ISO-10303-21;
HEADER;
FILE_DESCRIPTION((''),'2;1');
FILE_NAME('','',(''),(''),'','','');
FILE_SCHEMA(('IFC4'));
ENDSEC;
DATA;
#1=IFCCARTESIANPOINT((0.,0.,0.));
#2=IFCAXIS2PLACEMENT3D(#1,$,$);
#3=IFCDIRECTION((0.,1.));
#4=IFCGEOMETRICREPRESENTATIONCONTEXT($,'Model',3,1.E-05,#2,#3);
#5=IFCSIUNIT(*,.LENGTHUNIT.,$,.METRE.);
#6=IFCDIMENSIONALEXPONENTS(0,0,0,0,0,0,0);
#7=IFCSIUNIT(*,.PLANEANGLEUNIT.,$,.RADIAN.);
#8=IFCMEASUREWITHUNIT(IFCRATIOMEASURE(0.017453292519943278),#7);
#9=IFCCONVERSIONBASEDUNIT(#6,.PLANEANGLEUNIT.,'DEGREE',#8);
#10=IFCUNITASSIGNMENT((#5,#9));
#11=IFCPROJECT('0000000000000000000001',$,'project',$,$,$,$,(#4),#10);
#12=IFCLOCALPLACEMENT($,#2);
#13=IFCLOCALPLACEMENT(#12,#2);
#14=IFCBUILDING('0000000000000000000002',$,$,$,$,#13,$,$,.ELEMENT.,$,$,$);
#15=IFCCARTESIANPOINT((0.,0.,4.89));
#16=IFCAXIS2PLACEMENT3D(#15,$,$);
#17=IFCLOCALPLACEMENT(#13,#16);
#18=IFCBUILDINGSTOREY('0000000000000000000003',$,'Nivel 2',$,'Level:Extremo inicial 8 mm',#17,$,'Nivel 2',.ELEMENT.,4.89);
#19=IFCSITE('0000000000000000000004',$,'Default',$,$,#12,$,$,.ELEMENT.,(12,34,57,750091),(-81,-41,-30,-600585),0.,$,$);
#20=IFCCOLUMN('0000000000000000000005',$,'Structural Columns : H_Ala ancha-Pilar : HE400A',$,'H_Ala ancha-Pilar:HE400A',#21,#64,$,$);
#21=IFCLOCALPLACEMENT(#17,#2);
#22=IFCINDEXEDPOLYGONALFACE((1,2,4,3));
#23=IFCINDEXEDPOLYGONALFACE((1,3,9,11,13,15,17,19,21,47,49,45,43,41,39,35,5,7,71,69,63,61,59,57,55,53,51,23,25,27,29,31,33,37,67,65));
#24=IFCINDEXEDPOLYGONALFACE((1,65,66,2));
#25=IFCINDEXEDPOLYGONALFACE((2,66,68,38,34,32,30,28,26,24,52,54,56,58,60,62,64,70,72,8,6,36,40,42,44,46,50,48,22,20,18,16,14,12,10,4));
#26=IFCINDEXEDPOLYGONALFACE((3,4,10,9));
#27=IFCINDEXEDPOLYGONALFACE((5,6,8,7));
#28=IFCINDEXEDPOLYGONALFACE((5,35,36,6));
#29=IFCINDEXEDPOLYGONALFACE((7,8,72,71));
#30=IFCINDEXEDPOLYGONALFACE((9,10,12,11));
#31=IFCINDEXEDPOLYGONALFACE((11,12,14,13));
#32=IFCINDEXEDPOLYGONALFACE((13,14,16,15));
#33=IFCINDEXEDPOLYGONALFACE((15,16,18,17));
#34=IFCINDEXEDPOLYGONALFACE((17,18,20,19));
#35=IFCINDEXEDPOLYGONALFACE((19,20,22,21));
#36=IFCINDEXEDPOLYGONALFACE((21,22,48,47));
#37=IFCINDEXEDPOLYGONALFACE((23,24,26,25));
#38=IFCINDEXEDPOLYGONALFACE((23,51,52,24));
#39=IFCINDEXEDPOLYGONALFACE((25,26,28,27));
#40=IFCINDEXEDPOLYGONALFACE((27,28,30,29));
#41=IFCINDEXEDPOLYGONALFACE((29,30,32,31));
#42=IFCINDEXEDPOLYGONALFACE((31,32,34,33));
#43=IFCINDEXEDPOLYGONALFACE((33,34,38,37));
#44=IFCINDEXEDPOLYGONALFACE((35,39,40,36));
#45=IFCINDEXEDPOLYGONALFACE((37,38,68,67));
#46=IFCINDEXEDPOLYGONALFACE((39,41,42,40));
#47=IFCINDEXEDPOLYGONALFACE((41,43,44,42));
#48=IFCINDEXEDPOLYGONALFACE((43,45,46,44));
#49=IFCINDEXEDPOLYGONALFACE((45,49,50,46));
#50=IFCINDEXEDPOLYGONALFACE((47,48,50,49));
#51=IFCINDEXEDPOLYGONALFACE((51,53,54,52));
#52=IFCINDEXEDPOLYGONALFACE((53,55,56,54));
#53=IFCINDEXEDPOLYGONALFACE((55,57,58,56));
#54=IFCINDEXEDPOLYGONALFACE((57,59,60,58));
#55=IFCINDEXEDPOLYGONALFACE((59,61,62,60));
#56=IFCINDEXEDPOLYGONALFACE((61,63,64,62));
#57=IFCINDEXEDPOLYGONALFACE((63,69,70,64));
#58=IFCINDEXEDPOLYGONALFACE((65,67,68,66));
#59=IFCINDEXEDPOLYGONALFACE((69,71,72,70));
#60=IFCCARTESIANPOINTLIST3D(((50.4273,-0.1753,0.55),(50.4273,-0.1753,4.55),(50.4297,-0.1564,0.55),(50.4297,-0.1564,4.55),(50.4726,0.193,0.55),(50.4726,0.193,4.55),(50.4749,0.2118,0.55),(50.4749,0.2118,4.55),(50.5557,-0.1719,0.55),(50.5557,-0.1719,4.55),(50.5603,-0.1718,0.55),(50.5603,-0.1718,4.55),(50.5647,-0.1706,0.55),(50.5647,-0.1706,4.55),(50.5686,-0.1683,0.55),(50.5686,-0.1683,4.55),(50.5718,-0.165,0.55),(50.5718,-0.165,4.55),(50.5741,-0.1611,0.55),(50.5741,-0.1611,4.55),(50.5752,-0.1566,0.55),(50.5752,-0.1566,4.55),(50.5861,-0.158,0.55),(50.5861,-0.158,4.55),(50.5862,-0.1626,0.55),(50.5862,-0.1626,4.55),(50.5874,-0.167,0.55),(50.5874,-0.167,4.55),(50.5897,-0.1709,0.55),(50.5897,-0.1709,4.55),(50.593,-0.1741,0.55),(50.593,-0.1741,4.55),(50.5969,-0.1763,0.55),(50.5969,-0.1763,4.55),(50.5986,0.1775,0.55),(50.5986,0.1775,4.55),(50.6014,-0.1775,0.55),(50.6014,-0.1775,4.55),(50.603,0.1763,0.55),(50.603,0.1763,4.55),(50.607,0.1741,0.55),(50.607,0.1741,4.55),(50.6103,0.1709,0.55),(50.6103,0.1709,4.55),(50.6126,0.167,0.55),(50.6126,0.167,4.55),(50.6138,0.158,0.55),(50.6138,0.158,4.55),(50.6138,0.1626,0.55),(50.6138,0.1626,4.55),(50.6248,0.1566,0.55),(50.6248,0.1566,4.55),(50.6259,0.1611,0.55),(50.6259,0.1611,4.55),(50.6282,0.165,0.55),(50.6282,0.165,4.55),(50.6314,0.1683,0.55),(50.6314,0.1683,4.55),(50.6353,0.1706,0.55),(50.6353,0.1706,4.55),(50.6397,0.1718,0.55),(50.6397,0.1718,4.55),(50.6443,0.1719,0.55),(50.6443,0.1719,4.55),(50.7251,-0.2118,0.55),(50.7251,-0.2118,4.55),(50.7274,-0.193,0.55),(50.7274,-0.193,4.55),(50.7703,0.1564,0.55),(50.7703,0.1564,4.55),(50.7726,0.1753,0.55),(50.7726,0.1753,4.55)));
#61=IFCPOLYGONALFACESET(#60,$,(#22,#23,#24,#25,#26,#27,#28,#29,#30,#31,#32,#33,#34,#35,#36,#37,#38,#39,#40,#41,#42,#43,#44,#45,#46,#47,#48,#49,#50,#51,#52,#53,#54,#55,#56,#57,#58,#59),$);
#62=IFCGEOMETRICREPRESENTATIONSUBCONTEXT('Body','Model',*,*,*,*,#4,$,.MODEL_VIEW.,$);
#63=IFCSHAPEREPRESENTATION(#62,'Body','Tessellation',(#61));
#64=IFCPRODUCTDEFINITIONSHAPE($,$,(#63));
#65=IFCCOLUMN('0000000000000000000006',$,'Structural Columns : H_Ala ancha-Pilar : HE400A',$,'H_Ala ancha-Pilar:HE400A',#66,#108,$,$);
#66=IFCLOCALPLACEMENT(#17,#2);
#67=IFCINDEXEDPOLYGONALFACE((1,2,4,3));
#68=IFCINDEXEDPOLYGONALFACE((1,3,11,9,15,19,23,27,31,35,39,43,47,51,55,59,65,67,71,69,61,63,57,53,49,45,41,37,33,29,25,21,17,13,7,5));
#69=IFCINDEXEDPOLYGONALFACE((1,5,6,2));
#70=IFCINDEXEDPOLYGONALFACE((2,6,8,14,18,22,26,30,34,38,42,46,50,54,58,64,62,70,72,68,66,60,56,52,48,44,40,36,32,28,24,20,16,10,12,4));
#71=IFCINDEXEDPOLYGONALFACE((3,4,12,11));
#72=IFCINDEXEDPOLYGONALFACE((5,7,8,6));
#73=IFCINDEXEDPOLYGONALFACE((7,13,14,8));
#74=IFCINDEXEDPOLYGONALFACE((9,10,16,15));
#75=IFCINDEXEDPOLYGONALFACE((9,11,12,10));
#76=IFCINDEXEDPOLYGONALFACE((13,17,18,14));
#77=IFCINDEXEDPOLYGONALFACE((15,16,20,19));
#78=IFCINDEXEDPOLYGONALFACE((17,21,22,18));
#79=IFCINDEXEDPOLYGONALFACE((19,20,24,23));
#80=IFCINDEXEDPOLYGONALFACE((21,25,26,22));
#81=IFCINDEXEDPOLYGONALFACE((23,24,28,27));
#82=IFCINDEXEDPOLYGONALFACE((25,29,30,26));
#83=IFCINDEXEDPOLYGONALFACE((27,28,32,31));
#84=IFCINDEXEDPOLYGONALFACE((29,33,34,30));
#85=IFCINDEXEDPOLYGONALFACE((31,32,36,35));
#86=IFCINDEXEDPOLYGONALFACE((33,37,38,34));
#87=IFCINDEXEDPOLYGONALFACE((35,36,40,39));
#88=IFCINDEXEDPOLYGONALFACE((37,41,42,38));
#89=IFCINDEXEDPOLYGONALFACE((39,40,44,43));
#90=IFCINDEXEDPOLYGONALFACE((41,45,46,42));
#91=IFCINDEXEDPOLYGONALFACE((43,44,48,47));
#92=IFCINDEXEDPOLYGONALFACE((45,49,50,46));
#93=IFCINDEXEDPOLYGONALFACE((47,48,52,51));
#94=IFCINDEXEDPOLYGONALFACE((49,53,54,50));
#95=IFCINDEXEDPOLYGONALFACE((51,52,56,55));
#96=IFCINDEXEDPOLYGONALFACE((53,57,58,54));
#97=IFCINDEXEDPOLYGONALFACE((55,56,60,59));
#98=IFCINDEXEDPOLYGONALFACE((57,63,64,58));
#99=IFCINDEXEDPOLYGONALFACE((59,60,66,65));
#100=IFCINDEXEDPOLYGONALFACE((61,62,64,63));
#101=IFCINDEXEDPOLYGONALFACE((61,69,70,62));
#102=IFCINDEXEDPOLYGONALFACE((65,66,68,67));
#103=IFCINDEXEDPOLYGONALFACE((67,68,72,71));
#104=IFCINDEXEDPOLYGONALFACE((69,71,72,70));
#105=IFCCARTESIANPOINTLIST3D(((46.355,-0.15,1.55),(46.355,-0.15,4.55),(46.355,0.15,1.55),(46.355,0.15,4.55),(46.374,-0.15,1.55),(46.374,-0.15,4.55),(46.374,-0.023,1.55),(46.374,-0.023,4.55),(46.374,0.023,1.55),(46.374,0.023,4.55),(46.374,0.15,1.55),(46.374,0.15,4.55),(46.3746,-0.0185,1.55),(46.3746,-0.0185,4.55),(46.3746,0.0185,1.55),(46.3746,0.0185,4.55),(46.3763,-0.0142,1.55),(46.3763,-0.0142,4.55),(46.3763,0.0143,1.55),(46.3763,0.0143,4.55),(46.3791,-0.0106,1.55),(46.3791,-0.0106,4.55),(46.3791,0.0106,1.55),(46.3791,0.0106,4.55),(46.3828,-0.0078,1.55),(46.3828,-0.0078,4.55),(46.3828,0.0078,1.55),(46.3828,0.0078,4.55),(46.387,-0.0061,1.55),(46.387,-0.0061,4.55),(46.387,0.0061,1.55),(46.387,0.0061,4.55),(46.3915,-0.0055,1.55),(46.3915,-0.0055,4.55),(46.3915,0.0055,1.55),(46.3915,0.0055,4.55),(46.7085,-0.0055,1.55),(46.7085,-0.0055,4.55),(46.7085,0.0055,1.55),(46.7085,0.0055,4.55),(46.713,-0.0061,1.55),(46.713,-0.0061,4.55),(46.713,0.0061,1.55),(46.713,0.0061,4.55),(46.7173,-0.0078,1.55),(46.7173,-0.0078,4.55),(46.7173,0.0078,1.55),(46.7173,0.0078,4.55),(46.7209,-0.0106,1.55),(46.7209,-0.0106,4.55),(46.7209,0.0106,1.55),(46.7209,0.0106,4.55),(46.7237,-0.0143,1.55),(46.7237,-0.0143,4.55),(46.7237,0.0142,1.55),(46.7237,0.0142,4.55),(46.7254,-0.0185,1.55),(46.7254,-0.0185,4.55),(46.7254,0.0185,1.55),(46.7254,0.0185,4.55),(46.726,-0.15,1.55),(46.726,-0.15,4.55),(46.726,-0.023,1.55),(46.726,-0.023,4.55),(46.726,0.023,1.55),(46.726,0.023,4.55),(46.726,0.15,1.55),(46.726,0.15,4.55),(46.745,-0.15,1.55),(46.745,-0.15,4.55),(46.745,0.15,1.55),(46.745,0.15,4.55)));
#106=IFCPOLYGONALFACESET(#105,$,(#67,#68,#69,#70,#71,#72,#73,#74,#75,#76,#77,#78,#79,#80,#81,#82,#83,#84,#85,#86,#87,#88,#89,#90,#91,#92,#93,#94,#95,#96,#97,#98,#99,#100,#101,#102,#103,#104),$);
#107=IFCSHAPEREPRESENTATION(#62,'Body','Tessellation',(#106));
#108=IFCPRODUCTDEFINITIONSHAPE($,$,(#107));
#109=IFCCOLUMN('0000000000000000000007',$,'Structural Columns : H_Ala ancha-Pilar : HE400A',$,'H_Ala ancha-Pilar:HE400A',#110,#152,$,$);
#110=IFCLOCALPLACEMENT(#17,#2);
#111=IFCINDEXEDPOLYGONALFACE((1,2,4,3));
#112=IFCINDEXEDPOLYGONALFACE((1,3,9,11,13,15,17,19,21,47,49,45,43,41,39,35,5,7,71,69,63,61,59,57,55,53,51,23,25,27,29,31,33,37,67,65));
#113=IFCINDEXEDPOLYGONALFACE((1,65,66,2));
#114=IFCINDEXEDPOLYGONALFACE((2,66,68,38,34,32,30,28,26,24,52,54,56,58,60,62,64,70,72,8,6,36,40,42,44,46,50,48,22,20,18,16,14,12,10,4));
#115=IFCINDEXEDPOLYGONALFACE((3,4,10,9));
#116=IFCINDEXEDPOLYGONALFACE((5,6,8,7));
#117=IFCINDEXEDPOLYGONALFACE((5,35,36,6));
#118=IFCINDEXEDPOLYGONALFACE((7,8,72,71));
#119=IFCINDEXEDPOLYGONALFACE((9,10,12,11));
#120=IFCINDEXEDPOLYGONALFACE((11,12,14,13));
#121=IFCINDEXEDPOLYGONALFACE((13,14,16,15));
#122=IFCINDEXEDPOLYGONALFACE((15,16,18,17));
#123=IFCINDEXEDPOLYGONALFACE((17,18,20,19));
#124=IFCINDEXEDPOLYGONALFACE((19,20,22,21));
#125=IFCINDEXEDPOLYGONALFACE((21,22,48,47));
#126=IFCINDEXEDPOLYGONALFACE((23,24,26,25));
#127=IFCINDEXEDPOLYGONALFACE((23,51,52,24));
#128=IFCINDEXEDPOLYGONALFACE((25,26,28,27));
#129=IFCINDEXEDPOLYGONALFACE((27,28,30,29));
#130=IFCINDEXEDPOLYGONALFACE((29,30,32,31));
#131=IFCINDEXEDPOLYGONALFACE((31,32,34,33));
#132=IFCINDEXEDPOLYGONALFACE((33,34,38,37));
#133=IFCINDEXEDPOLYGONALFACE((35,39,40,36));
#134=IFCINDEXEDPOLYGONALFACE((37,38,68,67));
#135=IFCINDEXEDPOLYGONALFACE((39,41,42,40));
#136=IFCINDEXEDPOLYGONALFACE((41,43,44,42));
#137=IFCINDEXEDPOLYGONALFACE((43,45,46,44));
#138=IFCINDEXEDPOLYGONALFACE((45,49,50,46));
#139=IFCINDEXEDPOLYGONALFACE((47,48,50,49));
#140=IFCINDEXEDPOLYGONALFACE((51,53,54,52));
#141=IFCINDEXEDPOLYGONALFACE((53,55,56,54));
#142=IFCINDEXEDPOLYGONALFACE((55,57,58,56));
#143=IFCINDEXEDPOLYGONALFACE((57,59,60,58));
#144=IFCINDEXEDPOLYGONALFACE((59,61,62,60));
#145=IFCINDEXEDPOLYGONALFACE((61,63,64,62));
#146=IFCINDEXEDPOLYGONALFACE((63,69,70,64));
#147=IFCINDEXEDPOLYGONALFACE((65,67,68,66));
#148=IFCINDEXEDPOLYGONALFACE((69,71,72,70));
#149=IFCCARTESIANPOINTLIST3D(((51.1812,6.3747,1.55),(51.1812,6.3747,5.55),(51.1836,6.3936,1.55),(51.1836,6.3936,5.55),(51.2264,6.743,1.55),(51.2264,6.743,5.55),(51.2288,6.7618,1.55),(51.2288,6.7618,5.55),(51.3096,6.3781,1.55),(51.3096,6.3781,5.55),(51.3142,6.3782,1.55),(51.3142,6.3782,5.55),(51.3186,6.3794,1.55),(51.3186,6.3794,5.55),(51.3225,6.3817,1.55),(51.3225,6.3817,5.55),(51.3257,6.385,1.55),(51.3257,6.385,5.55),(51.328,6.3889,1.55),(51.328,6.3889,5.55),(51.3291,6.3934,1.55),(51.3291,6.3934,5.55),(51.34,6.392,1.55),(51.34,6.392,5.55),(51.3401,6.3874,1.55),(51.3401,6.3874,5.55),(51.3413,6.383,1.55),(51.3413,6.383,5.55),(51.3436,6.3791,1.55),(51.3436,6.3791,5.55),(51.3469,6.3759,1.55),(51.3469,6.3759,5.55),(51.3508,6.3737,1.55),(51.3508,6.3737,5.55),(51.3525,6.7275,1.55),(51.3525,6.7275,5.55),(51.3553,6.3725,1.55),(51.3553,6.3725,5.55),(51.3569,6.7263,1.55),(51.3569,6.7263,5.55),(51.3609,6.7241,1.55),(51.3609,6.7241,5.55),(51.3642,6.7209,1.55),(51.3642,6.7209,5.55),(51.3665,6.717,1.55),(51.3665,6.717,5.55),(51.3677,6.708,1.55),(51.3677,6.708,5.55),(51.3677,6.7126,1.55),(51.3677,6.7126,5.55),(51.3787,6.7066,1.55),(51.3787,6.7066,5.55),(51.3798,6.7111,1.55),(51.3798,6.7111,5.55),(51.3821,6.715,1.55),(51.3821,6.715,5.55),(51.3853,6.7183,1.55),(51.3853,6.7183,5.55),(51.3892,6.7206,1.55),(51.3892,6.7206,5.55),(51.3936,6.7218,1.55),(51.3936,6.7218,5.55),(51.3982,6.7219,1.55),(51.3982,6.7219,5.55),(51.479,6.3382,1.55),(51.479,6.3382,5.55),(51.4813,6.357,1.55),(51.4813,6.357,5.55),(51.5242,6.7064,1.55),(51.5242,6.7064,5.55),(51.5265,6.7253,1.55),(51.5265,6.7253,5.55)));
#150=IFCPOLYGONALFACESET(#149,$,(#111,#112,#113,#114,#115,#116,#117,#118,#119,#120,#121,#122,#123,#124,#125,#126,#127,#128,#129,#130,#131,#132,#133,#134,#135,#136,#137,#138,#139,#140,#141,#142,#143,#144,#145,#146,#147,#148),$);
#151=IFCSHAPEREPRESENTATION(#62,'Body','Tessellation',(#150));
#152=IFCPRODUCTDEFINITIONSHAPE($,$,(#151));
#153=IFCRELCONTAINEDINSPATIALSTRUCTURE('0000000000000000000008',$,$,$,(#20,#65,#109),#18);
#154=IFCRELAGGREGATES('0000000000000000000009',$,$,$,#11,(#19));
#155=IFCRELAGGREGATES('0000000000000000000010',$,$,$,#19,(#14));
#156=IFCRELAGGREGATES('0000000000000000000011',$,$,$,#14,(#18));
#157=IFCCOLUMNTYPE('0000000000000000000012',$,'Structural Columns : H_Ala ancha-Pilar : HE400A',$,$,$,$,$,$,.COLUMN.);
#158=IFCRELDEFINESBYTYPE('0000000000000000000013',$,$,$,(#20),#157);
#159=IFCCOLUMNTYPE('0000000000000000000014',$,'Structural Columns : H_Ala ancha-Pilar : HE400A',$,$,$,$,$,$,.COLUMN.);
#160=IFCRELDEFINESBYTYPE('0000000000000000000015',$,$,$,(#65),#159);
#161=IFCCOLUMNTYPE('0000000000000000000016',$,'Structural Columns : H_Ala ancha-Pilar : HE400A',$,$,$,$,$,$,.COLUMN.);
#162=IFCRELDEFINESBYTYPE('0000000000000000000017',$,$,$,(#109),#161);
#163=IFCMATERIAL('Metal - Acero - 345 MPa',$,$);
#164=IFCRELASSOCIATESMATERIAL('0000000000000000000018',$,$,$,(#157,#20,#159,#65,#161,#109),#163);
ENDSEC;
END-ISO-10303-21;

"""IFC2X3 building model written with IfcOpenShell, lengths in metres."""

from ifc_helpers import new_model, entity, si_unit, converted_unit, direction, frame, frame_2d, origin, place, context, subcontext, project, spatial, polyline, circle_curve, parameter, trimmed, segment, composite_curve, outline, extrude, source, transform, mapped, material, type_object, type_shapes, element, save


model = new_model("IFC2X3")

# Units and contexts
model_context = context("Model", 3, precision=1e-05, world=origin(), true_north=direction((0.0, 1.0)))
body_context = subcontext(model_context, "Body", "Model", "MODEL_VIEW")
ifc_project = project(units=[si_unit("LENGTHUNIT", "METRE"), converted_unit("PLANEANGLEUNIT", "DEGREE", entity("IfcRatioMeasure", 0.017453292519943278), si_unit("PLANEANGLEUNIT", "RADIAN"), dimensions=[0, 0, 0, 0, 0, 0, 0])], contexts=[model_context])

# Site, building, storey
site_placement = place(None, origin())
site = spatial("IfcSite", under=ifc_project, at=site_placement, Name="Default", CompositionType="ELEMENT", RefLatitude=(12, 34, 57, 750091), RefLongitude=(-81, -41, -30, -600585), RefElevation=0.0)
building_placement = place(site_placement, origin())
building = spatial("IfcBuilding", under=site, at=building_placement, CompositionType="ELEMENT")
storey_placement = place(building_placement, frame((0.0, 0.0, 4.89)))
storey = spatial("IfcBuildingStorey", under=building, at=storey_placement, Name="Nivel 2", ObjectType="Level:Extremo inicial 8 mm", LongName="Nivel 2", CompositionType="ELEMENT", Elevation=4.89)

# Columns
ifc_material_1 = material(Name="Metal - Acero - 345 MPa")
column_type_1 = type_object("IfcColumnType", Name="Structural Columns : H_Ala ancha-Pilar : HE400A", PredefinedType="COLUMN", material=ifc_material_1)
shared_shape_1 = source(origin(), body_context, "Body", "SweptSolid", [
    extrude(outline(composite_curve([segment(polyline([(0.176, -0.15), (0.195, -0.15)]), True, "CONTINUOUS"), segment(polyline([(0.195, -0.15), (0.195, 0.15)]), True, "CONTINUOUS"), segment(polyline([(0.195, 0.15), (0.176, 0.15)]), True, "CONTINUOUS"), segment(polyline([(0.176, 0.15), (0.176, 0.023)]), True, "CONTINUOUS"), segment(trimmed(circle_curve(frame_2d((0.1585, 0.023), x_axis=(1.0, 0.0)), 0.0175), [parameter(270.0)], [parameter(0.0)], True, "PARAMETER"), False, "CONTINUOUS"), segment(polyline([(0.1585, 0.0055), (-0.1585, 0.0055)]), True, "CONTINUOUS"), segment(trimmed(circle_curve(frame_2d((-0.1585, 0.023), x_axis=(0.0, -1.0)), 0.0175), [parameter(270.0)], [parameter(0.0)], True, "PARAMETER"), False, "CONTINUOUS"), segment(polyline([(-0.176, 0.023), (-0.176, 0.15)]), True, "CONTINUOUS"), segment(polyline([(-0.176, 0.15), (-0.195, 0.15)]), True, "CONTINUOUS"), segment(polyline([(-0.195, 0.15), (-0.195, -0.15)]), True, "CONTINUOUS"), segment(polyline([(-0.195, -0.15), (-0.176, -0.15)]), True, "CONTINUOUS"), segment(polyline([(-0.176, -0.15), (-0.176, -0.023)]), True, "CONTINUOUS"), segment(trimmed(circle_curve(frame_2d((-0.1585, -0.023), x_axis=(-1.0, 0.0)), 0.0175), [parameter(270.0)], [parameter(0.0)], True, "PARAMETER"), False, "CONTINUOUS"), segment(polyline([(-0.1585, -0.0055), (0.1585, -0.0055)]), True, "CONTINUOUS"), segment(trimmed(circle_curve(frame_2d((0.1585, -0.023), x_axis=(0.0, 1.0)), 0.0175), [parameter(270.0)], [parameter(0.0)], True, "PARAMETER"), False, "CONTINUOUS"), segment(polyline([(0.176, -0.023), (0.176, -0.15)]), True, "CONTINUOUS")], self_intersect=False)), frame((0.0, 0.0, 5.44), z_axis=(0.0, 0.0, 1.0), x_axis=(0.0, -1.0, 0.0)), (0.0, 0.0, 1.0), 4.0),
])
type_shapes(column_type_1, [shared_shape_1])
column_1_placement = place(storey_placement, frame((50.6, 0.0, -4.89), z_axis=(0.0, 0.0, 1.0), x_axis=(-0.992546, 0.121869, 0.0)))
element("IfcColumn", 1, at=column_1_placement, inside=storey, type_object=column_type_1, material=ifc_material_1, Name="Structural Columns : H_Ala ancha-Pilar : HE400A", ObjectType="H_Ala ancha-Pilar:HE400A", context=body_context, shape_type="MappedRepresentation", body=[
    mapped(shared_shape_1, transform((0.0, 0.0, 0.0), scale=1.0)),
])
column_type_2 = type_object("IfcColumnType", Name="Structural Columns : H_Ala ancha-Pilar : HE400A", PredefinedType="COLUMN", material=ifc_material_1)
shared_shape_2 = source(origin(), body_context, "Body", "SweptSolid", [
    extrude(outline(composite_curve([segment(polyline([(0.176, -0.15), (0.195, -0.15)]), True, "CONTINUOUS"), segment(polyline([(0.195, -0.15), (0.195, 0.15)]), True, "CONTINUOUS"), segment(polyline([(0.195, 0.15), (0.176, 0.15)]), True, "CONTINUOUS"), segment(polyline([(0.176, 0.15), (0.176, 0.023)]), True, "CONTINUOUS"), segment(trimmed(circle_curve(frame_2d((0.1585, 0.023), x_axis=(1.0, 0.0)), 0.0175), [parameter(270.0)], [parameter(0.0)], True, "PARAMETER"), False, "CONTINUOUS"), segment(polyline([(0.1585, 0.0055), (-0.1585, 0.0055)]), True, "CONTINUOUS"), segment(trimmed(circle_curve(frame_2d((-0.1585, 0.023), x_axis=(0.0, -1.0)), 0.0175), [parameter(270.0)], [parameter(0.0)], True, "PARAMETER"), False, "CONTINUOUS"), segment(polyline([(-0.176, 0.023), (-0.176, 0.15)]), True, "CONTINUOUS"), segment(polyline([(-0.176, 0.15), (-0.195, 0.15)]), True, "CONTINUOUS"), segment(polyline([(-0.195, 0.15), (-0.195, -0.15)]), True, "CONTINUOUS"), segment(polyline([(-0.195, -0.15), (-0.176, -0.15)]), True, "CONTINUOUS"), segment(polyline([(-0.176, -0.15), (-0.176, -0.023)]), True, "CONTINUOUS"), segment(trimmed(circle_curve(frame_2d((-0.1585, -0.023), x_axis=(-1.0, 0.0)), 0.0175), [parameter(270.0)], [parameter(0.0)], True, "PARAMETER"), False, "CONTINUOUS"), segment(polyline([(-0.1585, -0.0055), (0.1585, -0.0055)]), True, "CONTINUOUS"), segment(trimmed(circle_curve(frame_2d((0.1585, -0.023), x_axis=(0.0, 1.0)), 0.0175), [parameter(270.0)], [parameter(0.0)], True, "PARAMETER"), False, "CONTINUOUS"), segment(polyline([(0.176, -0.023), (0.176, -0.15)]), True, "CONTINUOUS")], self_intersect=False)), frame((0.0, 0.0, 6.44), z_axis=(0.0, 0.0, 1.0), x_axis=(0.0, -1.0, 0.0)), (0.0, 0.0, 1.0), 3.0),
])
type_shapes(column_type_2, [shared_shape_2])
column_2_placement = place(storey_placement, frame((46.55, 0.0, -4.89), z_axis=(0.0, 0.0, 1.0), x_axis=(0.0, 1.0, 0.0)))
element("IfcColumn", 2, at=column_2_placement, inside=storey, type_object=column_type_2, material=ifc_material_1, Name="Structural Columns : H_Ala ancha-Pilar : HE400A", ObjectType="H_Ala ancha-Pilar:HE400A", context=body_context, shape_type="MappedRepresentation", body=[
    mapped(shared_shape_2, transform((0.0, 0.0, 0.0), scale=1.0)),
])
column_type_3 = type_object("IfcColumnType", Name="Structural Columns : H_Ala ancha-Pilar : HE400A", PredefinedType="COLUMN", material=ifc_material_1)
shared_shape_3 = source(origin(), body_context, "Body", "SweptSolid", [
    extrude(outline(composite_curve([segment(polyline([(0.176, -0.15), (0.195, -0.15)]), True, "CONTINUOUS"), segment(polyline([(0.195, -0.15), (0.195, 0.15)]), True, "CONTINUOUS"), segment(polyline([(0.195, 0.15), (0.176, 0.15)]), True, "CONTINUOUS"), segment(polyline([(0.176, 0.15), (0.176, 0.023)]), True, "CONTINUOUS"), segment(trimmed(circle_curve(frame_2d((0.1585, 0.023), x_axis=(1.0, 0.0)), 0.0175), [parameter(270.0)], [parameter(0.0)], True, "PARAMETER"), False, "CONTINUOUS"), segment(polyline([(0.1585, 0.0055), (-0.1585, 0.0055)]), True, "CONTINUOUS"), segment(trimmed(circle_curve(frame_2d((-0.1585, 0.023), x_axis=(0.0, -1.0)), 0.0175), [parameter(270.0)], [parameter(0.0)], True, "PARAMETER"), False, "CONTINUOUS"), segment(polyline([(-0.176, 0.023), (-0.176, 0.15)]), True, "CONTINUOUS"), segment(polyline([(-0.176, 0.15), (-0.195, 0.15)]), True, "CONTINUOUS"), segment(polyline([(-0.195, 0.15), (-0.195, -0.15)]), True, "CONTINUOUS"), segment(polyline([(-0.195, -0.15), (-0.176, -0.15)]), True, "CONTINUOUS"), segment(polyline([(-0.176, -0.15), (-0.176, -0.023)]), True, "CONTINUOUS"), segment(trimmed(circle_curve(frame_2d((-0.1585, -0.023), x_axis=(-1.0, 0.0)), 0.0175), [parameter(270.0)], [parameter(0.0)], True, "PARAMETER"), False, "CONTINUOUS"), segment(polyline([(-0.1585, -0.0055), (0.1585, -0.0055)]), True, "CONTINUOUS"), segment(trimmed(circle_curve(frame_2d((0.1585, -0.023), x_axis=(0.0, 1.0)), 0.0175), [parameter(270.0)], [parameter(0.0)], True, "PARAMETER"), False, "CONTINUOUS"), segment(polyline([(0.176, -0.023), (0.176, -0.15)]), True, "CONTINUOUS")], self_intersect=False)), frame((0.0, 0.0, 6.44), z_axis=(0.0, 0.0, 1.0), x_axis=(0.0, -1.0, 0.0)), (0.0, 0.0, 1.0), 4.0),
])
type_shapes(column_type_3, [shared_shape_3])
column_3_placement = place(storey_placement, frame((51.3539, 6.55, -4.89), z_axis=(0.0, 0.0, 1.0), x_axis=(0.992546, -0.121869, 0.0)))
element("IfcColumn", 3, at=column_3_placement, inside=storey, type_object=column_type_3, material=ifc_material_1, Name="Structural Columns : H_Ala ancha-Pilar : HE400A", ObjectType="H_Ala ancha-Pilar:HE400A", context=body_context, shape_type="MappedRepresentation", body=[
    mapped(shared_shape_3, transform((0.0, 0.0, 0.0), scale=1.0)),
])

save(model, "model.ifc")
